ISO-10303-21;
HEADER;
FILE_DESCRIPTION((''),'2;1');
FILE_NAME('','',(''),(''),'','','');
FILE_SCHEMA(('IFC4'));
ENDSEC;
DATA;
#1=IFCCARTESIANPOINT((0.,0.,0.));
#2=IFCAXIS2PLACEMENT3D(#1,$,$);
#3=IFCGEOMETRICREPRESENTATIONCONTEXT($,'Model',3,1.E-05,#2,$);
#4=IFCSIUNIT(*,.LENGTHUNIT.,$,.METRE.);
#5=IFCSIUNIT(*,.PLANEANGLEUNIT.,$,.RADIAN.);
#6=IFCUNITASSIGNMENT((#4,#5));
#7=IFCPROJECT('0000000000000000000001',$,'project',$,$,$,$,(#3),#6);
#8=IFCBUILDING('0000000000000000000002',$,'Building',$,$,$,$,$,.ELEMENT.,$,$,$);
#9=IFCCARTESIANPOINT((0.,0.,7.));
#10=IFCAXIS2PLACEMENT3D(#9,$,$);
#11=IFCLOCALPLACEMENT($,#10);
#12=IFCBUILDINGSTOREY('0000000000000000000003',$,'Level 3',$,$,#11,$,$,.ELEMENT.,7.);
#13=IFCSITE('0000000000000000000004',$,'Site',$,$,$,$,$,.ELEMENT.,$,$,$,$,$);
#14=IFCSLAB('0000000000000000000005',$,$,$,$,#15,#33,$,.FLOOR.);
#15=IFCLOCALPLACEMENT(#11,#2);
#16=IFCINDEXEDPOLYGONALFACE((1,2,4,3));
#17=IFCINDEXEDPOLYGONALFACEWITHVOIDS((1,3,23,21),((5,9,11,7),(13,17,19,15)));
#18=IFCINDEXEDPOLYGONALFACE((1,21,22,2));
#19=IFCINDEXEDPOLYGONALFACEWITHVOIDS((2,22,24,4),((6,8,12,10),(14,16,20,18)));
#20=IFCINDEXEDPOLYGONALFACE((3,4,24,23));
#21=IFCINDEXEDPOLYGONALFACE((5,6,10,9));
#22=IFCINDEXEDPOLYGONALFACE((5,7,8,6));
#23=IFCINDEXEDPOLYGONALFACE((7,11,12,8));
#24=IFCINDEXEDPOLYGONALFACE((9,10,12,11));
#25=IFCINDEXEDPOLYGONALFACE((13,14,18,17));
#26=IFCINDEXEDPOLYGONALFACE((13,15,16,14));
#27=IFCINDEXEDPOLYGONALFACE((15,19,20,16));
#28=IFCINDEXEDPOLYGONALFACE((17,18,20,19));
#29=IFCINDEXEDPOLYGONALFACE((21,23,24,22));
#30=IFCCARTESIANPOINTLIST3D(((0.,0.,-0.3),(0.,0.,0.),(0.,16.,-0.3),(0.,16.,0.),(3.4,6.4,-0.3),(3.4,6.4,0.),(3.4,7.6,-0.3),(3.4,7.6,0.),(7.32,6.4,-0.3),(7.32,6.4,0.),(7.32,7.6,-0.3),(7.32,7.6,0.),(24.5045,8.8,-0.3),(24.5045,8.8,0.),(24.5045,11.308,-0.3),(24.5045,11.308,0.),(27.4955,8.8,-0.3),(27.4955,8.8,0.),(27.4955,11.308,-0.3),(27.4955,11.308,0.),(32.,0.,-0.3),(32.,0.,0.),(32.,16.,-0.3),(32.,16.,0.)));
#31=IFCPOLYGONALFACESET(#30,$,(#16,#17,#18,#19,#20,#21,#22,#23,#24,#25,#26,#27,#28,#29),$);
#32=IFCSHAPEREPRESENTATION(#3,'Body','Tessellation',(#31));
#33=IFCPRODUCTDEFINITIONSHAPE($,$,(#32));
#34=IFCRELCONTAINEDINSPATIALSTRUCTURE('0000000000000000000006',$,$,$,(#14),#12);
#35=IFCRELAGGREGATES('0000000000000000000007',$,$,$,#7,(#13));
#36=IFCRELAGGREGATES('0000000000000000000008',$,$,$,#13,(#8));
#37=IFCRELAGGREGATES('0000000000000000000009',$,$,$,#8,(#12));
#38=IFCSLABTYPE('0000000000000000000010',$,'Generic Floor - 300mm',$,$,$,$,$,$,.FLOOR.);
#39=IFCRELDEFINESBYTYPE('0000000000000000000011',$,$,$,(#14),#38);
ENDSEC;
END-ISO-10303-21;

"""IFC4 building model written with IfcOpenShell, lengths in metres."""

from ifc_helpers import new_model, si_unit, frame, origin, place, context, project, spatial, polyline, outline, extrude, type_object, element, save


model = new_model("IFC4")

# Units and contexts
model_context = context("Model", 3, precision=1e-05, world=origin())
ifc_project = project(units=[si_unit("LENGTHUNIT", "METRE"), si_unit("PLANEANGLEUNIT", "RADIAN")], contexts=[model_context])

# Site, building, storey
site = spatial("IfcSite", under=ifc_project, Name="Site", CompositionType="ELEMENT")
building = spatial("IfcBuilding", under=site, Name="Building", CompositionType="ELEMENT")
storey_placement = place(None, frame((0.0, 0.0, 7.0)))
storey = spatial("IfcBuildingStorey", under=building, at=storey_placement, Name="Level 3", CompositionType="ELEMENT", Elevation=7.0)

# Slab, openings
slab_type = type_object("IfcSlabType", Name="Generic Floor - 300mm", PredefinedType="FLOOR")
slab_placement = place(None, frame((0.0, 0.0, 7.0)))
slab = element("IfcSlab", 1, at=slab_placement, inside=storey, type_object=slab_type, PredefinedType="FLOOR", context=model_context, shape_type="SweptSolid", body=[
    extrude(outline(polyline([(0.0, 0.0), (32.0, 0.0), (32.0, 16.0), (0.0, 16.0), (0.0, 0.0)])), origin(), (0.0, 0.0, -1.0), 0.3),
])
opening_1_placement = place(None, frame((0.0, 0.0, 7.001)))
element("IfcOpeningElement", 2, at=opening_1_placement, cuts=slab, PredefinedType="OPENING", context=model_context, shape_type="SweptSolid", body=[
    extrude(outline(polyline([(3.4, 7.6), (3.4, 6.4), (7.32, 6.4), (7.32, 7.6), (3.4, 7.6)])), origin(), (0.0, 0.0, -1.0), 0.302),
])
opening_2_placement = place(None, frame((0.0, 0.0, 7.001)))
element("IfcOpeningElement", 3, at=opening_2_placement, cuts=slab, PredefinedType="OPENING", context=model_context, shape_type="SweptSolid", body=[
    extrude(outline(polyline([(24.5045, 8.8), (27.4955, 8.8), (27.4955, 11.308), (24.5045, 11.308), (24.5045, 8.8)])), origin(), (0.0, 0.0, -1.0), 0.302),
])

save(model, "model.ifc")
